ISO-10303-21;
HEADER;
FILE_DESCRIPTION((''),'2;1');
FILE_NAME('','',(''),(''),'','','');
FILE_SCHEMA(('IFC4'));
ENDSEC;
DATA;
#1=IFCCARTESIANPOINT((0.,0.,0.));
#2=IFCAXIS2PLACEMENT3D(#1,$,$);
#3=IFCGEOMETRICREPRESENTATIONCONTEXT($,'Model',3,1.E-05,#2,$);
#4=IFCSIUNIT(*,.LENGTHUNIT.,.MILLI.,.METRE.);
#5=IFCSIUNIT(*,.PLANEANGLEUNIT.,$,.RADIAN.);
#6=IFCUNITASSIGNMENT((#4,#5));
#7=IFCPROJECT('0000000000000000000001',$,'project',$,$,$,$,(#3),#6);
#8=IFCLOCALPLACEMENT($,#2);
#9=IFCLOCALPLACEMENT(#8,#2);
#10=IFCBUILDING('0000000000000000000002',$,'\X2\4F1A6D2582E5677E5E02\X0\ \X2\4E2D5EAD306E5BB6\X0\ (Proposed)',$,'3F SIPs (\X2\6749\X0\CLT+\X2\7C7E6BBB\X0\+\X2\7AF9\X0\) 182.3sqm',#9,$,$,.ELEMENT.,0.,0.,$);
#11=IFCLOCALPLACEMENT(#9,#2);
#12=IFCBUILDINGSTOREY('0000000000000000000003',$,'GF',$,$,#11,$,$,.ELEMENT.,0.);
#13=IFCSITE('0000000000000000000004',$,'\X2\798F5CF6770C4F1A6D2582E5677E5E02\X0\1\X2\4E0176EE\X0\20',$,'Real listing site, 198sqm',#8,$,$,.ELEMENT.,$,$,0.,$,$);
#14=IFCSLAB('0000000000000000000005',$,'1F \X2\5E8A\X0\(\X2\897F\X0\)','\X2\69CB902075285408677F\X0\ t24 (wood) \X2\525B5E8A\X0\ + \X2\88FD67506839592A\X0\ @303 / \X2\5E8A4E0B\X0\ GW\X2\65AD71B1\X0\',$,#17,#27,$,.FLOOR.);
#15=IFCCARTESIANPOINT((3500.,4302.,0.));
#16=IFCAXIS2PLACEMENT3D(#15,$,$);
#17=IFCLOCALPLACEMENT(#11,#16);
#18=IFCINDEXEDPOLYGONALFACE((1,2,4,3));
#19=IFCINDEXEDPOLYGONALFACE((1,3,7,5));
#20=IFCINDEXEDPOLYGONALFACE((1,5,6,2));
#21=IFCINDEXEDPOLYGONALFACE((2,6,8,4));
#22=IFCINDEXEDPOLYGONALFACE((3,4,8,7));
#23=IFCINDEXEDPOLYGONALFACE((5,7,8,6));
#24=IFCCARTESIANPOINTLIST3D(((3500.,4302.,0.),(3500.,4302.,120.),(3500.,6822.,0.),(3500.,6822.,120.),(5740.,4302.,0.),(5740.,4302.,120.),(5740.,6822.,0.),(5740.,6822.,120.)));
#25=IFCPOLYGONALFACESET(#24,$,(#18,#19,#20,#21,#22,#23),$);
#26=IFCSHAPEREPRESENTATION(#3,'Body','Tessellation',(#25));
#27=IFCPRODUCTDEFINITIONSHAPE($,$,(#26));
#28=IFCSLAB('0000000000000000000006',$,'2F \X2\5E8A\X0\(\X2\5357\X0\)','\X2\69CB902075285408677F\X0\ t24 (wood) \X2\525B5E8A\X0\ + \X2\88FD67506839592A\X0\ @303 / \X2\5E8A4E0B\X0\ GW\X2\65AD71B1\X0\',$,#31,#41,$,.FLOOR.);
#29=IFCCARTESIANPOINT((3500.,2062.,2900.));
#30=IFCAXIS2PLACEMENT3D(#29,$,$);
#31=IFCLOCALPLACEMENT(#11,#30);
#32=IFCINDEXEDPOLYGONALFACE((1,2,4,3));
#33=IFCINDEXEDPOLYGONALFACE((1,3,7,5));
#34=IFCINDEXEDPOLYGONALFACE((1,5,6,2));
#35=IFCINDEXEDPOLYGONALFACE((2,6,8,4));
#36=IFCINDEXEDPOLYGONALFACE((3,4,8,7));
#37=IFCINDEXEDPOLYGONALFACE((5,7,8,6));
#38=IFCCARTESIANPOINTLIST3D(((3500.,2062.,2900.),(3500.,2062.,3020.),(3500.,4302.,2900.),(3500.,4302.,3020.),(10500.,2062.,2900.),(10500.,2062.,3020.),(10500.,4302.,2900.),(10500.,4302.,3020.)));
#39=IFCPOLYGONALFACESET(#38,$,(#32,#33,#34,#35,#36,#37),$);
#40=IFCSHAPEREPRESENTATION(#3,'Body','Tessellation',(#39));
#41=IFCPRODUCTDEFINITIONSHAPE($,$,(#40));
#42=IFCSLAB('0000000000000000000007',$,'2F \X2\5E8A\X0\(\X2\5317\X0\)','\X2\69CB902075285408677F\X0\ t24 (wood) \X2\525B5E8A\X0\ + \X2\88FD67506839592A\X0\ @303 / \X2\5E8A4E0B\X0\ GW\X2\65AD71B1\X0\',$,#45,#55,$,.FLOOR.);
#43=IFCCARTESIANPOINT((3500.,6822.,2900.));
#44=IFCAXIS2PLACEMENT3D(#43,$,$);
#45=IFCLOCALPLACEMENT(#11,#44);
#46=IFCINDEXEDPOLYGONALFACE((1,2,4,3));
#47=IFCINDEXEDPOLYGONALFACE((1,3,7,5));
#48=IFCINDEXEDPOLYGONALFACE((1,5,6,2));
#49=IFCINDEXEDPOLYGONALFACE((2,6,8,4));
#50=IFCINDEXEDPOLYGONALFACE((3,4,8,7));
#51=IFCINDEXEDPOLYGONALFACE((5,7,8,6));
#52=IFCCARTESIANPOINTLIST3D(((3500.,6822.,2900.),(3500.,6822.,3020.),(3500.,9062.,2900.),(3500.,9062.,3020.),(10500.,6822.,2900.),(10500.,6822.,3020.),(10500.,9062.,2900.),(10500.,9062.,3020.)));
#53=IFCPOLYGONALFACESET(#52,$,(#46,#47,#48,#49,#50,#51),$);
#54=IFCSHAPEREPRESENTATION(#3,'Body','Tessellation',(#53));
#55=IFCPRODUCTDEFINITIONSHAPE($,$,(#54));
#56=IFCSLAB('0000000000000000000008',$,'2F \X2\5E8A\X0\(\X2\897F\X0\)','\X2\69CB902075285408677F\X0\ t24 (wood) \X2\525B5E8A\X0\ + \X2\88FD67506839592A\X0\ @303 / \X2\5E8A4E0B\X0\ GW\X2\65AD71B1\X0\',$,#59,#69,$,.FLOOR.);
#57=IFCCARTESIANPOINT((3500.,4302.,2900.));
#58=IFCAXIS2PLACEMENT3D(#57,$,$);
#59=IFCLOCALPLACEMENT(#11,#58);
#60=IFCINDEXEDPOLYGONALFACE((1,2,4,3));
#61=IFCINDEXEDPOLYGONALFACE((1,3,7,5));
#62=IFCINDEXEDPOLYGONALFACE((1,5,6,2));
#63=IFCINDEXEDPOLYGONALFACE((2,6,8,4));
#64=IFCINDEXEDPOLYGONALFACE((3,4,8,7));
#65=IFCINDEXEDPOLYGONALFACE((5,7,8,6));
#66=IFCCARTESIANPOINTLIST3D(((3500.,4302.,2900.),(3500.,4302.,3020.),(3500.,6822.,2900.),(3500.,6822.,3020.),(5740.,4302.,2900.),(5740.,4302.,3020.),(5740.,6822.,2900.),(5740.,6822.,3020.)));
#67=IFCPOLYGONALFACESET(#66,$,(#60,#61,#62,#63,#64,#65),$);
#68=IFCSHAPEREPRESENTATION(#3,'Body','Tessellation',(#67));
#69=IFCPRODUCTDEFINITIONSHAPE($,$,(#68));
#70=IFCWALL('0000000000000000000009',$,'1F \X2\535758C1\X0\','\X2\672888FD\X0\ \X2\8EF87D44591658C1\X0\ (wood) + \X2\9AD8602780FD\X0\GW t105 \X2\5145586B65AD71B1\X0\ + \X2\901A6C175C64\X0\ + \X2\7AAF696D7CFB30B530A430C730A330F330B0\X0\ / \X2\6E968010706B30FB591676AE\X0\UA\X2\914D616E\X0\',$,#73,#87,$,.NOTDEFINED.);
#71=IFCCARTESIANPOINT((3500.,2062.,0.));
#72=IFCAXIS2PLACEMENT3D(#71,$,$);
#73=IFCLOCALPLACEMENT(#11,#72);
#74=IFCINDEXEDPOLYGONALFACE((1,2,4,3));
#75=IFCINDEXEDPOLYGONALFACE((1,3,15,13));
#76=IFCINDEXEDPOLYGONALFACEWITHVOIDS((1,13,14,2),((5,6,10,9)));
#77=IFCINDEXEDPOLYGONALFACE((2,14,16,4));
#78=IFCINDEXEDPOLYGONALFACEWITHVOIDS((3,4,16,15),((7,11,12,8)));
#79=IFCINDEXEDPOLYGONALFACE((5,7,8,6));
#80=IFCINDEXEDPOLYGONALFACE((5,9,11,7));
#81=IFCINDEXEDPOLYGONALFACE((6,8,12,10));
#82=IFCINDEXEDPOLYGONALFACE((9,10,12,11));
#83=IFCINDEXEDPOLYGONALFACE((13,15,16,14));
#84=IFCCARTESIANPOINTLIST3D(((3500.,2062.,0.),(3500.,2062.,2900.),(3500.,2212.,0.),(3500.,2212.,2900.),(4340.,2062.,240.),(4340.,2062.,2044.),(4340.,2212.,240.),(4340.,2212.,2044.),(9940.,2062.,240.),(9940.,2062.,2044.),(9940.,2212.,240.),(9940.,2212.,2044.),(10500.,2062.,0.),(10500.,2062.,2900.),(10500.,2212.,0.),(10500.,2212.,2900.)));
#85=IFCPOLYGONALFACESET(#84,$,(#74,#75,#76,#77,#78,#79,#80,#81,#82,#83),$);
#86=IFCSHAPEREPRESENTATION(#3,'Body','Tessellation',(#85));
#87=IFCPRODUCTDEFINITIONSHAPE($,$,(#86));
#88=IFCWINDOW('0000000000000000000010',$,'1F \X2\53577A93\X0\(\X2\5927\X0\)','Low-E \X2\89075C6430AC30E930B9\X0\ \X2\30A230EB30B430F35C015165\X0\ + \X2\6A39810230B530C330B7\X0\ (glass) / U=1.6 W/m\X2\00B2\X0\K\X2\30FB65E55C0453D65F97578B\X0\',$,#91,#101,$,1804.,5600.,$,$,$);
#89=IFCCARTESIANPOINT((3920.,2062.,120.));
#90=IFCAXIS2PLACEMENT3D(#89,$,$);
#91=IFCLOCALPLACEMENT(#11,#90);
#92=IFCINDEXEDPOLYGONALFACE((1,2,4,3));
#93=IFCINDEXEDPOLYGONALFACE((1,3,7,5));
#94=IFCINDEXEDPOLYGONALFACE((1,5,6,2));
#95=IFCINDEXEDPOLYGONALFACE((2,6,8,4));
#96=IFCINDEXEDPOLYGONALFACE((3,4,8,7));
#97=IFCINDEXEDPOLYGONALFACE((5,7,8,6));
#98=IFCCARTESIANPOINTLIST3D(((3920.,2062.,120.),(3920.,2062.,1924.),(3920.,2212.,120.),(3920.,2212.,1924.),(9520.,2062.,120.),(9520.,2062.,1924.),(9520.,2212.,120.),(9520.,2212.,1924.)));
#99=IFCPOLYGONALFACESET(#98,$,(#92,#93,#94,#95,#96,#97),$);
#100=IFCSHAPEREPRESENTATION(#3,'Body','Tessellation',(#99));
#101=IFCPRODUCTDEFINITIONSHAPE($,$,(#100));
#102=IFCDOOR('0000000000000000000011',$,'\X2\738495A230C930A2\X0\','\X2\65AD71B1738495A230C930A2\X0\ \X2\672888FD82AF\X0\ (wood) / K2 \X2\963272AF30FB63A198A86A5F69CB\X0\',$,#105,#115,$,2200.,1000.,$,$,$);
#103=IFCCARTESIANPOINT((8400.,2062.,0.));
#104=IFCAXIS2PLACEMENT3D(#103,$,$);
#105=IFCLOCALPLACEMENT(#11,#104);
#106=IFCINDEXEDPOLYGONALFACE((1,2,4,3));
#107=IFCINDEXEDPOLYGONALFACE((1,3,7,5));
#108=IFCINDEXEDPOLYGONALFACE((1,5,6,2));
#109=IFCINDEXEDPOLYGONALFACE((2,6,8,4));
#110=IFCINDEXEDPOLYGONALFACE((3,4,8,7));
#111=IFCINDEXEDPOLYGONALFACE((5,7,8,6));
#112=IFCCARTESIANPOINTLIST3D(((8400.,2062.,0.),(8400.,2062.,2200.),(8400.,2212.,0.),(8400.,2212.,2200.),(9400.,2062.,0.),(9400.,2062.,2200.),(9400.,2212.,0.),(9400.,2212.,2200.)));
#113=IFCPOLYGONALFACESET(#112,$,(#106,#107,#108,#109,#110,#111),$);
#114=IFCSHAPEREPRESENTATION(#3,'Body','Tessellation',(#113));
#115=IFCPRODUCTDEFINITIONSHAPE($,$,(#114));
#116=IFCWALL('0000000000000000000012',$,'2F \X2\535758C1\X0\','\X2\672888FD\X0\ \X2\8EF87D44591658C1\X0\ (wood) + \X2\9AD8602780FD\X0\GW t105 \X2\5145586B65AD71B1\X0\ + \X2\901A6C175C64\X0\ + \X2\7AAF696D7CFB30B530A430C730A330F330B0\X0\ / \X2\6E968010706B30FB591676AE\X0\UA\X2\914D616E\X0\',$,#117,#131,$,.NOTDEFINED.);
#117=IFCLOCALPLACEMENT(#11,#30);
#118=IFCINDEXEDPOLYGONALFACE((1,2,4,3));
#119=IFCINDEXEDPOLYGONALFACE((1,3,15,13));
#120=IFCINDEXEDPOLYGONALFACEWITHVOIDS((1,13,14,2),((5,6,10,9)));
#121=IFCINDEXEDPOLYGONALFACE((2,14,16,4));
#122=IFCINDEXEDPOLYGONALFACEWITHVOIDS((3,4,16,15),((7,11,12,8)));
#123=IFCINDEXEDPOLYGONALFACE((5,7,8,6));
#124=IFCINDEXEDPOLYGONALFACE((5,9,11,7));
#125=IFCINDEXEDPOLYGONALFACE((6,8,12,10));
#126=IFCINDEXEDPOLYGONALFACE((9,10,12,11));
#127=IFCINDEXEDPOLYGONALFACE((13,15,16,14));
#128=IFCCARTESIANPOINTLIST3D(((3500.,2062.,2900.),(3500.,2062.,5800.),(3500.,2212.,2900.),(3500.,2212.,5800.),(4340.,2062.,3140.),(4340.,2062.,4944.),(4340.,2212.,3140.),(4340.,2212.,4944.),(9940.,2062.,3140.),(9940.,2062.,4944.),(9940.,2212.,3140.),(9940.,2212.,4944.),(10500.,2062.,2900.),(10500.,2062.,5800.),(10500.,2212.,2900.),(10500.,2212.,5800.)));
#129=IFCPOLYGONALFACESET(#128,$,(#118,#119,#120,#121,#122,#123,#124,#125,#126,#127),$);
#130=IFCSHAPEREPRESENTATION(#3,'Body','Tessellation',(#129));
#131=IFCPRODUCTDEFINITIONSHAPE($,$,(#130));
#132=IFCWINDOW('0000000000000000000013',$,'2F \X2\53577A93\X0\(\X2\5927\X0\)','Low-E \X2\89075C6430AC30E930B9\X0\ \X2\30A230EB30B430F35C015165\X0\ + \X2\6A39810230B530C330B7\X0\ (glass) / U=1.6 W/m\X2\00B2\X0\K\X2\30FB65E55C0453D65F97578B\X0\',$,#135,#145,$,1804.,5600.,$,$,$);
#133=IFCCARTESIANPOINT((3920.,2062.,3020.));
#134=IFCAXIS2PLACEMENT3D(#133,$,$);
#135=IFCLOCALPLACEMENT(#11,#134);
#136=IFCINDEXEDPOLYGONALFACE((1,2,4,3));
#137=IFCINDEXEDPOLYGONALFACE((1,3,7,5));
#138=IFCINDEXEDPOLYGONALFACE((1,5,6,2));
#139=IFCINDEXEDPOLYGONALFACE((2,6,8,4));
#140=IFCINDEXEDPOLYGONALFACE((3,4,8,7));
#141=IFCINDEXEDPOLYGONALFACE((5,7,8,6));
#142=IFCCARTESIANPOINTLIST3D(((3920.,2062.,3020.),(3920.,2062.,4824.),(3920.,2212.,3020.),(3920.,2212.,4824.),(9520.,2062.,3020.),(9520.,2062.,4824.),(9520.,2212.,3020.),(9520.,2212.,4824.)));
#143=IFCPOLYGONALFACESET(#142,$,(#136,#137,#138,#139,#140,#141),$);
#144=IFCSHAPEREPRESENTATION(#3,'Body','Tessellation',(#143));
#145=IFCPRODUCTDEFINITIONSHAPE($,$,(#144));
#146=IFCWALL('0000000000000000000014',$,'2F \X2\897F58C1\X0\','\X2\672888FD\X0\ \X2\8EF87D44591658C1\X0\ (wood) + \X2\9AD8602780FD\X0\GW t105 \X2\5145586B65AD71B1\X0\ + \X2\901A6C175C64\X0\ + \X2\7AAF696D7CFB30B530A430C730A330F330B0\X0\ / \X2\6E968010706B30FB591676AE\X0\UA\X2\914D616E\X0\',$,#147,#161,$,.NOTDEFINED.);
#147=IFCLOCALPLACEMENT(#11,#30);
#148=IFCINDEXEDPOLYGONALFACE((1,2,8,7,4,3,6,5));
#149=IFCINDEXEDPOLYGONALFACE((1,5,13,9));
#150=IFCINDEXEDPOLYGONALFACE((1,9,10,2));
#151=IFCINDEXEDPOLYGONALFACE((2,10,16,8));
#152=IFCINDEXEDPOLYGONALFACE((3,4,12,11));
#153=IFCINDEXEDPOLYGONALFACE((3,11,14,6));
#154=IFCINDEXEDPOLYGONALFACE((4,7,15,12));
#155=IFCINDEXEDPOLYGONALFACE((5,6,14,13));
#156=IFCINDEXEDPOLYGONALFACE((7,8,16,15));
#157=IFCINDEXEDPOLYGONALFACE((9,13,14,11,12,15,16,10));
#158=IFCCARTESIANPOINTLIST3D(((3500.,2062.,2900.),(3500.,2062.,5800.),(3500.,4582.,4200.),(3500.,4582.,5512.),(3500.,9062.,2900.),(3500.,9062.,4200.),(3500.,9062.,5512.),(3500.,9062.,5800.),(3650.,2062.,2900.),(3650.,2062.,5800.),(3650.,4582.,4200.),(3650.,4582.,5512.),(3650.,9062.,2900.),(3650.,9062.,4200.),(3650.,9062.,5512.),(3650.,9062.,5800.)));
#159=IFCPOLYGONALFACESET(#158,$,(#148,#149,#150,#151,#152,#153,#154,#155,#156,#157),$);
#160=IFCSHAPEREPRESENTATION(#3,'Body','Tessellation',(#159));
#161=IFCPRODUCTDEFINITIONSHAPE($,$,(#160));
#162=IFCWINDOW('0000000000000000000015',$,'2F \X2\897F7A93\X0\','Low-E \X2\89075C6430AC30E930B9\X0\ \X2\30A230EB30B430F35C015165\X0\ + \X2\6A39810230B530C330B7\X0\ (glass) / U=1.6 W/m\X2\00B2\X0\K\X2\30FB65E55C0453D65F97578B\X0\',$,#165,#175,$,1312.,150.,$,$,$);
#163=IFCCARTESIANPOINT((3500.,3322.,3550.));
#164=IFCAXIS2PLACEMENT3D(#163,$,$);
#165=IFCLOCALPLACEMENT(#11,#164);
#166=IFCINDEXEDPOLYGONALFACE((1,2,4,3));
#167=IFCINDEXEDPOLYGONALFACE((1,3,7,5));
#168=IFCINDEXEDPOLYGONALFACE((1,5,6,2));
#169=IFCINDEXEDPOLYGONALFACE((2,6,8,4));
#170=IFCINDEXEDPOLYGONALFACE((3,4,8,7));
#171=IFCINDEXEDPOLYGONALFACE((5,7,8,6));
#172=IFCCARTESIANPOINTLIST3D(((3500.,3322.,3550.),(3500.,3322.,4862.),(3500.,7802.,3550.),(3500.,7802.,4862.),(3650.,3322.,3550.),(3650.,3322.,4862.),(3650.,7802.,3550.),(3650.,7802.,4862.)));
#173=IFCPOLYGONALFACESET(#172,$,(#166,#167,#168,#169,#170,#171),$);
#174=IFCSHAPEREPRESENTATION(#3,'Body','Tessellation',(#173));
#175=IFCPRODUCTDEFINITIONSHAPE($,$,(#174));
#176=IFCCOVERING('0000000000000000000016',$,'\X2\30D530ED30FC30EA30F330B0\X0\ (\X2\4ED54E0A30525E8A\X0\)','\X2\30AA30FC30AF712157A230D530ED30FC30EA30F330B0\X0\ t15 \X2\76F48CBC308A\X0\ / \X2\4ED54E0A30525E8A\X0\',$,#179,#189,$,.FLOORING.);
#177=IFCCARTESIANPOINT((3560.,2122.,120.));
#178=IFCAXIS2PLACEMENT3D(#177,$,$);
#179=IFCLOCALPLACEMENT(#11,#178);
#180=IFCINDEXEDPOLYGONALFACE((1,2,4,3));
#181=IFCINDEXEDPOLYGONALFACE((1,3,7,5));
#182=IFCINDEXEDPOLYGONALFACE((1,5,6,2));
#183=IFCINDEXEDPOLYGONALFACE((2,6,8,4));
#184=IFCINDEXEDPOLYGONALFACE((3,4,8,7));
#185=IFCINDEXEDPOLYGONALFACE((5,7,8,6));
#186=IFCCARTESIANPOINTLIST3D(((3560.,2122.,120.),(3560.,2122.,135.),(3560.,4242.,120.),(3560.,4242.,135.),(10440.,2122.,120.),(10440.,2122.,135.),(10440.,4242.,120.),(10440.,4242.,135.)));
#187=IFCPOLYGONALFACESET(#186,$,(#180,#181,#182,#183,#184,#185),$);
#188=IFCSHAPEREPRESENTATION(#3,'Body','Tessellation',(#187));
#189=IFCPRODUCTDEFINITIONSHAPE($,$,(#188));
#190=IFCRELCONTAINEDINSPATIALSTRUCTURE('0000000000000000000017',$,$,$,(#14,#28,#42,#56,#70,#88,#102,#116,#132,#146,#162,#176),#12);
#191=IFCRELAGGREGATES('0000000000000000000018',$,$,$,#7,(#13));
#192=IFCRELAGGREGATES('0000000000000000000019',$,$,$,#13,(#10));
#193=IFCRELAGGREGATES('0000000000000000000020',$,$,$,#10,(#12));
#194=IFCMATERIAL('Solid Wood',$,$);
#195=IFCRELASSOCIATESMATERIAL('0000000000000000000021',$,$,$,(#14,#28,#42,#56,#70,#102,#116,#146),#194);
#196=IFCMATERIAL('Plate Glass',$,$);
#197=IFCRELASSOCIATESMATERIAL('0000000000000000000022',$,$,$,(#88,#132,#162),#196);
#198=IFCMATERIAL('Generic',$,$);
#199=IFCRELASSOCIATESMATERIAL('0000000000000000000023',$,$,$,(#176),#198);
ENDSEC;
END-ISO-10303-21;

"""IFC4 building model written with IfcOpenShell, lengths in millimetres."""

from ifc_helpers import new_model, si_unit, frame, frame_2d, origin, place, context, project, spatial, rectangle, extrude, material, element, fill, save


model = new_model("IFC4")

# Units and contexts
model_context = context("Model", 3, precision=1e-05, world=origin())
ifc_project = project(units=[si_unit("LENGTHUNIT", "METRE", prefix="MILLI"), si_unit("PLANEANGLEUNIT", "RADIAN")], contexts=[model_context])

# Site, building, storey
site_placement = place(None, origin())
site = spatial("IfcSite", under=ifc_project, at=site_placement, Name="福島県会津若松市1丁目20", ObjectType="Real listing site, 198sqm", CompositionType="ELEMENT", RefElevation=0.0)
building_placement = place(site_placement, origin())
building = spatial("IfcBuilding", under=site, at=building_placement, Name="会津若松市 中庭の家 (Proposed)", ObjectType="3F SIPs (杉CLT+籾殻+竹) 182.3sqm", CompositionType="ELEMENT", ElevationOfRefHeight=0.0, ElevationOfTerrain=0.0)
storey_placement = place(building_placement, origin())
storey = spatial("IfcBuildingStorey", under=building, at=storey_placement, Name="GF", CompositionType="ELEMENT", Elevation=0.0)

# Slabs
ifc_material_1 = material(Name="Solid Wood")
slab_1_placement = place(storey_placement, frame((3500.0, 4302.0, 0.0)))
element("IfcSlab", 1, at=slab_1_placement, inside=storey, material=ifc_material_1, Name="1F 床(西)", Description="構造用合板 t24 (wood) 剛床 + 製材根太 @303 / 床下 GW断熱", PredefinedType="FLOOR", context=model_context, shape_type="SweptSolid", body=[
    extrude(rectangle(XDim=2240.0, YDim=2520.0, at=frame_2d((1120.0, 1260.0))), frame((3500.0, 4302.0, 0.0)), (0.0, 0.0, 1.0), 120.0),
])
slab_2_placement = place(storey_placement, frame((3500.0, 2062.0, 2900.0)))
element("IfcSlab", 2, at=slab_2_placement, inside=storey, material=ifc_material_1, Name="2F 床(南)", Description="構造用合板 t24 (wood) 剛床 + 製材根太 @303 / 床下 GW断熱", PredefinedType="FLOOR", context=model_context, shape_type="SweptSolid", body=[
    extrude(rectangle(XDim=7000.0, YDim=2240.0, at=frame_2d((3500.0, 1120.0))), frame((3500.0, 2062.0, 2900.0)), (0.0, 0.0, 1.0), 120.0),
])
slab_3_placement = place(storey_placement, frame((3500.0, 6822.0, 2900.0)))
element("IfcSlab", 3, at=slab_3_placement, inside=storey, material=ifc_material_1, Name="2F 床(北)", Description="構造用合板 t24 (wood) 剛床 + 製材根太 @303 / 床下 GW断熱", PredefinedType="FLOOR", context=model_context, shape_type="SweptSolid", body=[
    extrude(rectangle(XDim=7000.0, YDim=2240.0, at=frame_2d((3500.0, 1120.0))), frame((3500.0, 6822.0, 2900.0)), (0.0, 0.0, 1.0), 120.0),
])
slab_4_placement = place(storey_placement, frame((3500.0, 4302.0, 2900.0)))
element("IfcSlab", 4, at=slab_4_placement, inside=storey, material=ifc_material_1, Name="2F 床(西)", Description="構造用合板 t24 (wood) 剛床 + 製材根太 @303 / 床下 GW断熱", PredefinedType="FLOOR", context=model_context, shape_type="SweptSolid", body=[
    extrude(rectangle(XDim=2240.0, YDim=2520.0, at=frame_2d((1120.0, 1260.0))), frame((3500.0, 4302.0, 2900.0)), (0.0, 0.0, 1.0), 120.0),
])

# Wall, openings, window, door
wall_1_placement = place(storey_placement, frame((3500.0, 2062.0, 0.0)))
wall_1 = element("IfcWall", 5, at=wall_1_placement, inside=storey, material=ifc_material_1, Name="1F 南壁", Description="木製 軸組外壁 (wood) + 高性能GW t105 充填断熱 + 通気層 + 窯業系サイディング / 準耐火・外皮UA配慮", PredefinedType="NOTDEFINED", context=model_context, shape_type="SweptSolid", body=[
    extrude(rectangle(XDim=7000.0, YDim=150.0, at=frame_2d((3500.0, 75.0))), frame((3500.0, 2062.0, 0.0)), (0.0, 0.0, 1.0), 2900.0),
])
opening_1_placement = place(storey_placement, frame((3920.0, 2062.0, 120.0)))
opening_1 = element("IfcOpeningElement", 6, at=opening_1_placement, cuts=wall_1, PredefinedType="NOTDEFINED", context=model_context, shape_type="SweptSolid", body=[
    extrude(rectangle(XDim=5600.0, YDim=150.0, at=frame_2d((2800.0, 75.0))), frame((3920.0, 2062.0, 120.0)), (0.0, 0.0, 1.0), 1804.0),
])
opening_2_placement = place(storey_placement, frame((8400.0, 2062.0, 0.0)))
opening_2 = element("IfcOpeningElement", 7, at=opening_2_placement, cuts=wall_1, PredefinedType="NOTDEFINED", context=model_context, shape_type="SweptSolid", body=[
    extrude(rectangle(XDim=1000.0, YDim=150.0, at=frame_2d((500.0, 75.0))), frame((8400.0, 2062.0, 0.0)), (0.0, 0.0, 1.0), 2200.0),
])
ifc_material_2 = material(Name="Plate Glass")
window_1_placement = place(storey_placement, frame((3920.0, 2062.0, 120.0)))
window_1 = element("IfcWindow", 8, at=window_1_placement, inside=storey, material=ifc_material_2, Name="1F 南窓(大)", Description="Low-E 複層ガラス アルゴン封入 + 樹脂サッシ (glass) / U=1.6 W/m²K・日射取得型", OverallHeight=1804.0, OverallWidth=5600.0, context=model_context, shape_type="SweptSolid", body=[
    extrude(rectangle(XDim=5600.0, YDim=150.0, at=frame_2d((2800.0, 75.0))), frame((3920.0, 2062.0, 120.0)), (0.0, 0.0, 1.0), 1804.0),
])
fill(opening_1, window_1)
door_placement = place(storey_placement, frame((8400.0, 2062.0, 0.0)))
door = element("IfcDoor", 9, at=door_placement, inside=storey, material=ifc_material_1, Name="玄関ドア", Description="断熱玄関ドア 木製芯 (wood) / K2 防犯・採風機構", OverallHeight=2200.0, OverallWidth=1000.0, context=model_context, shape_type="SweptSolid", body=[
    extrude(rectangle(XDim=1000.0, YDim=150.0, at=frame_2d((500.0, 75.0))), frame((8400.0, 2062.0, 0.0)), (0.0, 0.0, 1.0), 2200.0),
])
fill(opening_2, door)

# Wall, opening, window
wall_2_placement = place(storey_placement, frame((3500.0, 2062.0, 2900.0)))
wall_2 = element("IfcWall", 10, at=wall_2_placement, inside=storey, material=ifc_material_1, Name="2F 南壁", Description="木製 軸組外壁 (wood) + 高性能GW t105 充填断熱 + 通気層 + 窯業系サイディング / 準耐火・外皮UA配慮", PredefinedType="NOTDEFINED", context=model_context, shape_type="SweptSolid", body=[
    extrude(rectangle(XDim=7000.0, YDim=150.0, at=frame_2d((3500.0, 75.0))), frame((3500.0, 2062.0, 2900.0)), (0.0, 0.0, 1.0), 2900.0),
])
opening_3_placement = place(storey_placement, frame((3920.0, 2062.0, 3020.0)))
opening_3 = element("IfcOpeningElement", 11, at=opening_3_placement, cuts=wall_2, PredefinedType="NOTDEFINED", context=model_context, shape_type="SweptSolid", body=[
    extrude(rectangle(XDim=5600.0, YDim=150.0, at=frame_2d((2800.0, 75.0))), frame((3920.0, 2062.0, 3020.0)), (0.0, 0.0, 1.0), 1804.0),
])
window_2_placement = place(storey_placement, frame((3920.0, 2062.0, 3020.0)))
window_2 = element("IfcWindow", 12, at=window_2_placement, inside=storey, material=ifc_material_2, Name="2F 南窓(大)", Description="Low-E 複層ガラス アルゴン封入 + 樹脂サッシ (glass) / U=1.6 W/m²K・日射取得型", OverallHeight=1804.0, OverallWidth=5600.0, context=model_context, shape_type="SweptSolid", body=[
    extrude(rectangle(XDim=5600.0, YDim=150.0, at=frame_2d((2800.0, 75.0))), frame((3920.0, 2062.0, 3020.0)), (0.0, 0.0, 1.0), 1804.0),
])
fill(opening_3, window_2)

# Wall, opening, window
wall_3_placement = place(storey_placement, frame((3500.0, 2062.0, 2900.0)))
wall_3 = element("IfcWall", 13, at=wall_3_placement, inside=storey, material=ifc_material_1, Name="2F 西壁", Description="木製 軸組外壁 (wood) + 高性能GW t105 充填断熱 + 通気層 + 窯業系サイディング / 準耐火・外皮UA配慮", PredefinedType="NOTDEFINED", context=model_context, shape_type="SweptSolid", body=[
    extrude(rectangle(XDim=150.0, YDim=7000.0, at=frame_2d((75.0, 3500.0))), frame((3500.0, 2062.0, 2900.0)), (0.0, 0.0, 1.0), 2900.0),
])
opening_4_placement = place(storey_placement, frame((3500.0, 3322.0, 3550.0)))
opening_4 = element("IfcOpeningElement", 14, at=opening_4_placement, cuts=wall_3, PredefinedType="NOTDEFINED", context=model_context, shape_type="SweptSolid", body=[
    extrude(rectangle(XDim=150.0, YDim=4480.0, at=frame_2d((75.0, 2240.0))), frame((3500.0, 3322.0, 3550.0)), (0.0, 0.0, 1.0), 1312.0),
])
window_3_placement = place(storey_placement, frame((3500.0, 3322.0, 3550.0)))
window_3 = element("IfcWindow", 15, at=window_3_placement, inside=storey, material=ifc_material_2, Name="2F 西窓", Description="Low-E 複層ガラス アルゴン封入 + 樹脂サッシ (glass) / U=1.6 W/m²K・日射取得型", OverallHeight=1312.0, OverallWidth=150.0, context=model_context, shape_type="SweptSolid", body=[
    extrude(rectangle(XDim=150.0, YDim=4480.0, at=frame_2d((75.0, 2240.0))), frame((3500.0, 3322.0, 3550.0)), (0.0, 0.0, 1.0), 1312.0),
])
fill(opening_4, window_3)

# Covering
ifc_material_3 = material(Name="Generic")
covering_1_placement = place(storey_placement, frame((3560.0, 2122.0, 120.0)))
element("IfcCovering", 16, at=covering_1_placement, inside=storey, material=ifc_material_3, Name="フローリング (仕上げ床)", Description="オーク無垢フローリング t15 直貼り / 仕上げ床", PredefinedType="FLOORING", context=model_context, shape_type="SweptSolid", body=[
    extrude(rectangle(XDim=6880.0, YDim=2120.0, at=frame_2d((3440.0, 1060.0))), frame((3560.0, 2122.0, 120.0)), (0.0, 0.0, 1.0), 15.0),
])

save(model, "model.ifc")
